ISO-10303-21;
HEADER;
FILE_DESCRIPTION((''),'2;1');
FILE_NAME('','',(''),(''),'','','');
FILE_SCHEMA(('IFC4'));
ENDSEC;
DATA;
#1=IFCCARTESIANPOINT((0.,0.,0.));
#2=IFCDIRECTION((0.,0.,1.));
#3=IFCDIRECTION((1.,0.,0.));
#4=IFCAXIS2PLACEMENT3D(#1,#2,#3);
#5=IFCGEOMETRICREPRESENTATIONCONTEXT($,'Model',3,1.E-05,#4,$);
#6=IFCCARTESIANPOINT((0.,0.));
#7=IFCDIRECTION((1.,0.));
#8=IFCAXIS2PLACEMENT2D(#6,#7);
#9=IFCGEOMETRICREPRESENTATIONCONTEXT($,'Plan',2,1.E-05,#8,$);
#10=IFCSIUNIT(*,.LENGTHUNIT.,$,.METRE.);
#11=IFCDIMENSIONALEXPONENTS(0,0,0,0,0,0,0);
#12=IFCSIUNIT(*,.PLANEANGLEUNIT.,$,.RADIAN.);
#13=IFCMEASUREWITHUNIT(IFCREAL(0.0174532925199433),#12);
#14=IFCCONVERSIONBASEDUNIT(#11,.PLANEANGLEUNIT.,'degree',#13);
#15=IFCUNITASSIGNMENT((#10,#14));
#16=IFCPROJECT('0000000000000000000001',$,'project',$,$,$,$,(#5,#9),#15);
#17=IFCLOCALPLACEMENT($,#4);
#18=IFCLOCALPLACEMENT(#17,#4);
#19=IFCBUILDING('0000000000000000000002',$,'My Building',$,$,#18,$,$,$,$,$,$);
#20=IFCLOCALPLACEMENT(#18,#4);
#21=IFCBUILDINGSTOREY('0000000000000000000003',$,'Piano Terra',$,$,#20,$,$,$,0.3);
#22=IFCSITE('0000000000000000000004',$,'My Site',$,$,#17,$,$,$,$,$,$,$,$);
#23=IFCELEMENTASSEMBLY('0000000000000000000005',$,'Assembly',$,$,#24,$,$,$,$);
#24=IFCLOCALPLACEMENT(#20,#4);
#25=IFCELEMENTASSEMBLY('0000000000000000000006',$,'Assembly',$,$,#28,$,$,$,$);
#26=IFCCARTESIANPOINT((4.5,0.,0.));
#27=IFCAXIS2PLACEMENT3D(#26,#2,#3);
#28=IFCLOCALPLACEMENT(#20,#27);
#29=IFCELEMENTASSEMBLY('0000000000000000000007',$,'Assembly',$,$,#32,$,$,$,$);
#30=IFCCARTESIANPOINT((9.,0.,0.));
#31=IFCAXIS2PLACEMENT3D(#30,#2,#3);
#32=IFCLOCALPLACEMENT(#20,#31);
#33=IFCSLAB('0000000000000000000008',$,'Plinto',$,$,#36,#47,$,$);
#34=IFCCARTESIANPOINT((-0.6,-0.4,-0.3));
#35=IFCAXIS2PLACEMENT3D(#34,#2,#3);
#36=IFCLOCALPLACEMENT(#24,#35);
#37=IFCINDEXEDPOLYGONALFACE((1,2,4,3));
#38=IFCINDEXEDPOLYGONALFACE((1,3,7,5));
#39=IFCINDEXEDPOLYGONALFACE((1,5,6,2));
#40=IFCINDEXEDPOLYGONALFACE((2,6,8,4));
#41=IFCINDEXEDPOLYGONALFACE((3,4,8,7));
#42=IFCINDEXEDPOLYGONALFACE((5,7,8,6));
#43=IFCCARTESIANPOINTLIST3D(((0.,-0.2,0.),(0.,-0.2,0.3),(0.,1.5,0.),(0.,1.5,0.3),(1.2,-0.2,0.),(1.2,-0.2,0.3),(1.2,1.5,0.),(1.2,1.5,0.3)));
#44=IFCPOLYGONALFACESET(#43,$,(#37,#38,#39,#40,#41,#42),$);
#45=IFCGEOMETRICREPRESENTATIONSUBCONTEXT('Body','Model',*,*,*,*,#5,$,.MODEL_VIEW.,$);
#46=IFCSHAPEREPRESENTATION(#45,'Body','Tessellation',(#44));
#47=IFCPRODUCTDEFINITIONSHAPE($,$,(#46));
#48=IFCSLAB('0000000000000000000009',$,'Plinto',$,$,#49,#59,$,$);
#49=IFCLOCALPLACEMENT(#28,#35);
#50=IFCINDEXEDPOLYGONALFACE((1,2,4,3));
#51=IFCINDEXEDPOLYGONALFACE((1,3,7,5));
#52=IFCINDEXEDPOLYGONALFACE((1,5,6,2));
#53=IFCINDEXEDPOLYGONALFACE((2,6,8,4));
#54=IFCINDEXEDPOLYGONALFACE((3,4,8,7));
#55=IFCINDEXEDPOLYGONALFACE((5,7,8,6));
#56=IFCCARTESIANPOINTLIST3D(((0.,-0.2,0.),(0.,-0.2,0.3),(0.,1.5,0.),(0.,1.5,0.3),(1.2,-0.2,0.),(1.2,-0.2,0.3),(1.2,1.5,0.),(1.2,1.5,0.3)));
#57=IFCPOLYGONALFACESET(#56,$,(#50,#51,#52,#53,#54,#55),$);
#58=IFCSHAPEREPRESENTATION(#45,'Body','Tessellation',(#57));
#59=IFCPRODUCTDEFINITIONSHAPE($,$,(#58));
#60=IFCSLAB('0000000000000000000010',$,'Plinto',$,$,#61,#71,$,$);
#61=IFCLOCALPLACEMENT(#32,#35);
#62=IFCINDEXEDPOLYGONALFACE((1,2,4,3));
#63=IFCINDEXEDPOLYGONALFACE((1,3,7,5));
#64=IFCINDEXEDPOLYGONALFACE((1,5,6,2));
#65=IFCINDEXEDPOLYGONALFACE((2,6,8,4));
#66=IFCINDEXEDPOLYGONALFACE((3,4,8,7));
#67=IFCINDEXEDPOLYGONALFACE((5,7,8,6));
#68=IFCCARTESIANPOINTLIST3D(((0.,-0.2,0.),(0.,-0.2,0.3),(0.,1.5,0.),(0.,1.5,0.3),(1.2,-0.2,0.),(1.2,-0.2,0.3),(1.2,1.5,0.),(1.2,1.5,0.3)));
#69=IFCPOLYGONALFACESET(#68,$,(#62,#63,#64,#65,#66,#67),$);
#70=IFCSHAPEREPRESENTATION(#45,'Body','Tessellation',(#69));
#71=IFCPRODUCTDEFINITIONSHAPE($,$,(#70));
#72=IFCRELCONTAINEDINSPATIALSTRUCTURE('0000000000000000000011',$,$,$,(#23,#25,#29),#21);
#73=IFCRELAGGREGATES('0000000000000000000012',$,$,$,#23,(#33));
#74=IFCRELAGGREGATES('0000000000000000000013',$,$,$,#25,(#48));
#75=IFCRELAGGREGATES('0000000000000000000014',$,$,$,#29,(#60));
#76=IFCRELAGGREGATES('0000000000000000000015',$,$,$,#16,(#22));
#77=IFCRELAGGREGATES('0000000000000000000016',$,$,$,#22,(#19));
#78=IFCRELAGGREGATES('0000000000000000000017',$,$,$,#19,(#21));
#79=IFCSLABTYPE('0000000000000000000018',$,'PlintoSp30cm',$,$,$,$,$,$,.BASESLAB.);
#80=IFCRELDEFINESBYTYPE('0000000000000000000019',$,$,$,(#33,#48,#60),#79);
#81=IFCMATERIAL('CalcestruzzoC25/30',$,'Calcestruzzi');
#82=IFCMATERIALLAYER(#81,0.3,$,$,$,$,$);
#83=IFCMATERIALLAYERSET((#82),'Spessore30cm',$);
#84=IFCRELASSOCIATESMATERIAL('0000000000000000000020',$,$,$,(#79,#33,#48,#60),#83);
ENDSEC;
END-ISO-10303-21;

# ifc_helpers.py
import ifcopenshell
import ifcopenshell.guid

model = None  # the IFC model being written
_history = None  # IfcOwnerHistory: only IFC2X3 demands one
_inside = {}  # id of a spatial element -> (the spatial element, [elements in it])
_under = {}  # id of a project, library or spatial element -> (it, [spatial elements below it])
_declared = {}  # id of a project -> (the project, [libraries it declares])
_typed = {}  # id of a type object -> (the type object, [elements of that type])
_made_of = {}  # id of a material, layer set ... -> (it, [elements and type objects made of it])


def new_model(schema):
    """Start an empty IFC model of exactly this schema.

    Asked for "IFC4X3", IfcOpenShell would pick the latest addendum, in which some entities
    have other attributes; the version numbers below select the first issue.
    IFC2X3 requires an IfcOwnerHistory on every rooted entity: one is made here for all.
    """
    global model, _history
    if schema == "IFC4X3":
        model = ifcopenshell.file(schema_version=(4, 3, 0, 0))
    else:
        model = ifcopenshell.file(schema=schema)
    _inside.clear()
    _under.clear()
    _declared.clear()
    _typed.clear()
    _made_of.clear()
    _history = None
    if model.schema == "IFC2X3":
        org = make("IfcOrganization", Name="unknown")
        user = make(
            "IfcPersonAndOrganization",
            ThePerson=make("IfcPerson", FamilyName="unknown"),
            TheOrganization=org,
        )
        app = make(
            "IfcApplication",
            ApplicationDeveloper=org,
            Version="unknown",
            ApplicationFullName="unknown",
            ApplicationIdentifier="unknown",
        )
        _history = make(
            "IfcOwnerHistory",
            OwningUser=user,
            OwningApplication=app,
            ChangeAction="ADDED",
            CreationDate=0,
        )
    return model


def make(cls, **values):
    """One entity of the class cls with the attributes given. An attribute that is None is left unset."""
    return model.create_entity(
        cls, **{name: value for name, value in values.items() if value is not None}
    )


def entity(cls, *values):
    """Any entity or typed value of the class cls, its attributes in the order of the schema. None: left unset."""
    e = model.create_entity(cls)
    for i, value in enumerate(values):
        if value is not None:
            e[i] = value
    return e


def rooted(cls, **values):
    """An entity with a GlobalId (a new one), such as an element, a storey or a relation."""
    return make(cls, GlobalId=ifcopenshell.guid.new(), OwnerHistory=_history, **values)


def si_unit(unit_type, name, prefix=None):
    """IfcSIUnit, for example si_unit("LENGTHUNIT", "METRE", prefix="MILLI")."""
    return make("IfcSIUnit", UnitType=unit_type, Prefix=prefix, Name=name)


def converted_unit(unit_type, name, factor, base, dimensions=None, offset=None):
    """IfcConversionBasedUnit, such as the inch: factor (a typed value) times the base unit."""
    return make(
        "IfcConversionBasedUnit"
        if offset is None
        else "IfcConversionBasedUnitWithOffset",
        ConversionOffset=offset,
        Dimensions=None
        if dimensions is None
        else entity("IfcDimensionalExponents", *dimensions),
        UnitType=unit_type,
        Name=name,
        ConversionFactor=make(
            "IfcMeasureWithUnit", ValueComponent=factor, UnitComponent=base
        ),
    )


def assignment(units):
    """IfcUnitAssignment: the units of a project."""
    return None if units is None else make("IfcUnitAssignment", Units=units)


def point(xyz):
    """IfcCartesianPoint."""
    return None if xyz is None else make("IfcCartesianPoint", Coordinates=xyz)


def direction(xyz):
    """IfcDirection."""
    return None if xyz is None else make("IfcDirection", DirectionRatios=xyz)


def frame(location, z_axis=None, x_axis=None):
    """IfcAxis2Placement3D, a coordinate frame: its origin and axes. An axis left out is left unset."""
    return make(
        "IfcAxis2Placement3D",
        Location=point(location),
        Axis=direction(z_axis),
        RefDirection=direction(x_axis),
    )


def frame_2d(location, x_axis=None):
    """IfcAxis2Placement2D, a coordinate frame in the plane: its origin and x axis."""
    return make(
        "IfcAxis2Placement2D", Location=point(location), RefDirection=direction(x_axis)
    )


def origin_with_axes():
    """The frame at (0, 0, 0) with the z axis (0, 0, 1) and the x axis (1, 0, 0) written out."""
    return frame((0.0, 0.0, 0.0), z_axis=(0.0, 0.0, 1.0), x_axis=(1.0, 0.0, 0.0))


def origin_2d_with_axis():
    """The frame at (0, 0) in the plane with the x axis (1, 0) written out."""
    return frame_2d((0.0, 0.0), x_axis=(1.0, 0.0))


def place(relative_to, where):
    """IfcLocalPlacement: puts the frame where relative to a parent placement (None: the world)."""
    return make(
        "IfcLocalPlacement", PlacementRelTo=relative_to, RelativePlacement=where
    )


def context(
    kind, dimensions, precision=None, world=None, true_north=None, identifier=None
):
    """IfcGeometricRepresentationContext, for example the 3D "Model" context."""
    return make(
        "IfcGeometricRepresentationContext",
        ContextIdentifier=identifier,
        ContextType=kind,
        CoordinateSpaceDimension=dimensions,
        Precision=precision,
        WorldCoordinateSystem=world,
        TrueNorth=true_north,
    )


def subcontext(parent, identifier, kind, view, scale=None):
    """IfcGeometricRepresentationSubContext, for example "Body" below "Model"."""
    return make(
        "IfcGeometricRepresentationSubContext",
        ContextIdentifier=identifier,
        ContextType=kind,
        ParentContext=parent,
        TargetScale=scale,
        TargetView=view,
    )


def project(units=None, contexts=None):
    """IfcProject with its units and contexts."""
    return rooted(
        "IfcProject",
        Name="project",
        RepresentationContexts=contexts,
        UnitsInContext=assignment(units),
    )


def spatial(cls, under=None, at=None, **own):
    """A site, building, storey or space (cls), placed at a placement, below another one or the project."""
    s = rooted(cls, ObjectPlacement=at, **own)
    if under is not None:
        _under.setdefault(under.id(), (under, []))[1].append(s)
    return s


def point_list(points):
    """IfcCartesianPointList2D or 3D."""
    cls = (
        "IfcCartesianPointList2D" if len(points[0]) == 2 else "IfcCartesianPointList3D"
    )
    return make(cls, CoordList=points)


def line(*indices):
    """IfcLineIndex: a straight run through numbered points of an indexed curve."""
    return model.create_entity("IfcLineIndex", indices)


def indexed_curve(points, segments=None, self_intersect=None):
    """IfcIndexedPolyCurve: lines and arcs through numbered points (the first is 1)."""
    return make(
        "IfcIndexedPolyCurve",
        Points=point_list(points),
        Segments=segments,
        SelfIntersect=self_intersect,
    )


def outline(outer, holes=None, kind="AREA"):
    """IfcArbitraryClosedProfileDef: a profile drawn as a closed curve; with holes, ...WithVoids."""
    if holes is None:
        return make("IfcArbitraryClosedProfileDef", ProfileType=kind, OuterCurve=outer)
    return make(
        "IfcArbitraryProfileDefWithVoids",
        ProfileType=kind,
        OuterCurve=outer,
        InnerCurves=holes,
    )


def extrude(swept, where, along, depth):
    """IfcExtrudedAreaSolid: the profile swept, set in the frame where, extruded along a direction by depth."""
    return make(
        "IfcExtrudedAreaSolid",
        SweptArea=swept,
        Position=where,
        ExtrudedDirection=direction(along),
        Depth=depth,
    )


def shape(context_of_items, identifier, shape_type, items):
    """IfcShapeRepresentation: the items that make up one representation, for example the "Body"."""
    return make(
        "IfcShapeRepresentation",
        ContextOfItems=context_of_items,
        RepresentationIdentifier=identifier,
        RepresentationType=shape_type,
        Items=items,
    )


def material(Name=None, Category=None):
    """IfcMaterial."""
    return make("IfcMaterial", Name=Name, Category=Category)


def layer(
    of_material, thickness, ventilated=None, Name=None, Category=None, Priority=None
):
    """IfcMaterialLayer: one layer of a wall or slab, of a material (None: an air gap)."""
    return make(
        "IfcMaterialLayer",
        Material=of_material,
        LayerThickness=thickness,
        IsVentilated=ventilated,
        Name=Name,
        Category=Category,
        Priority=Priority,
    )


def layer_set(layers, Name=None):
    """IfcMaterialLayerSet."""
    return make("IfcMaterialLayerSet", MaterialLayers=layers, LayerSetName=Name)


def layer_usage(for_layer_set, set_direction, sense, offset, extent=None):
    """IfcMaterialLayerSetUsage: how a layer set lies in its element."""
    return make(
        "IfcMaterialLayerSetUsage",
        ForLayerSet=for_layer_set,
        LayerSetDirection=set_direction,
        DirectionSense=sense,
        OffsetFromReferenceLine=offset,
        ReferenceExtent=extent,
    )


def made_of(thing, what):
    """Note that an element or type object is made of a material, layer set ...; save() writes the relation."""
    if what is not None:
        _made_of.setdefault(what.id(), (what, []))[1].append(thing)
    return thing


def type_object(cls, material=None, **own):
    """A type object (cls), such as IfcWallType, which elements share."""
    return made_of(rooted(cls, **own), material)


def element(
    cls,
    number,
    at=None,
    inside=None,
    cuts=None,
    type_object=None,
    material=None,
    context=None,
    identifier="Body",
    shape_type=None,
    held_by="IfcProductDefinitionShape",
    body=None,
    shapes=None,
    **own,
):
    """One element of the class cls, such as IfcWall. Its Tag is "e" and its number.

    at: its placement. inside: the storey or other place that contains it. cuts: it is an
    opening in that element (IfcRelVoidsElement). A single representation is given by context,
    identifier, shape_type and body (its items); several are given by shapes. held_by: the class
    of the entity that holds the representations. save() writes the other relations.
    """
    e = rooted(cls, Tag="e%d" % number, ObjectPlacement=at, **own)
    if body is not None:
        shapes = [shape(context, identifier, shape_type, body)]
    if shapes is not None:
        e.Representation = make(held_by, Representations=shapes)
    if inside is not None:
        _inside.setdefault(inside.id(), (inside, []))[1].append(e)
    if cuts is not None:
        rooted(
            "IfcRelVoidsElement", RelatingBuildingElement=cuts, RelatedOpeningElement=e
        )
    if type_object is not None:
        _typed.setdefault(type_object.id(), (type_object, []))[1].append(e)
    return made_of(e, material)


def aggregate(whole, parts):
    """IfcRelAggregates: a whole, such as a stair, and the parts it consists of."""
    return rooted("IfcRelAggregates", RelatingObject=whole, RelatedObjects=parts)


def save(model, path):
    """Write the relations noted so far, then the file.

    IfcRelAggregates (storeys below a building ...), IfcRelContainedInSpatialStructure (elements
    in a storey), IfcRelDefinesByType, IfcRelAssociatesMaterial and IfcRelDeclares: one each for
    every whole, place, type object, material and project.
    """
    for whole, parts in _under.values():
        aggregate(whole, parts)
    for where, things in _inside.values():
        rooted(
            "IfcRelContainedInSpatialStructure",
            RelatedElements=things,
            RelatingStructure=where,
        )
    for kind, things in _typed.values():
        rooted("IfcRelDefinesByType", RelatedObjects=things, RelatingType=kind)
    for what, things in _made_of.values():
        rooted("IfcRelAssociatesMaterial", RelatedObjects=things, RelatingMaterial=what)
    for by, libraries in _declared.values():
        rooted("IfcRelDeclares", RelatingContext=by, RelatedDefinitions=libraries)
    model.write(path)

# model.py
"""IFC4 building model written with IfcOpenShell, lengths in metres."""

from ifc_helpers import new_model, entity, si_unit, converted_unit, frame, origin_with_axes, origin_2d_with_axis, place, context, subcontext, project, spatial, line, indexed_curve, outline, extrude, material, layer, layer_set, layer_usage, type_object, element, aggregate, save


model = new_model("IFC4")

# Units and contexts
model_context = context("Model", 3, precision=1e-05, world=origin_with_axes())
plan_context = context("Plan", 2, precision=1e-05, world=origin_2d_with_axis())
body_context = subcontext(model_context, "Body", "Model", "MODEL_VIEW")
ifc_project = project(units=[si_unit("LENGTHUNIT", "METRE"), converted_unit("PLANEANGLEUNIT", "degree", entity("IfcReal", 0.0174532925199433), si_unit("PLANEANGLEUNIT", "RADIAN"), dimensions=[0, 0, 0, 0, 0, 0, 0])], contexts=[model_context, plan_context])

# Site, building, storey
site_placement = place(None, origin_with_axes())
site = spatial("IfcSite", under=ifc_project, at=site_placement, Name="My Site")
building_placement = place(site_placement, origin_with_axes())
building = spatial("IfcBuilding", under=site, at=building_placement, Name="My Building")
storey_placement = place(building_placement, origin_with_axes())
storey = spatial("IfcBuildingStorey", under=building, at=storey_placement, Name="Piano Terra", Elevation=0.3)

# Element assemblies
assembly_1_placement = place(storey_placement, origin_with_axes())
assembly_1 = element("IfcElementAssembly", 1, at=assembly_1_placement, inside=storey, Name="Assembly")
assembly_2_placement = place(storey_placement, frame((4.5, 0.0, 0.0), z_axis=(0.0, 0.0, 1.0), x_axis=(1.0, 0.0, 0.0)))
assembly_2 = element("IfcElementAssembly", 2, at=assembly_2_placement, inside=storey, Name="Assembly")
assembly_3_placement = place(storey_placement, frame((9.0, 0.0, 0.0), z_axis=(0.0, 0.0, 1.0), x_axis=(1.0, 0.0, 0.0)))
assembly_3 = element("IfcElementAssembly", 3, at=assembly_3_placement, inside=storey, Name="Assembly")

# Slabs
ifc_material_1 = material(Name="CalcestruzzoC25/30", Category="Calcestruzzi")
ifc_layer = layer(ifc_material_1, 0.3)
ifc_layer_set = layer_set([ifc_layer], Name="Spessore30cm")
ifc_layer_usage_1 = layer_usage(ifc_layer_set, "AXIS3", "POSITIVE", 0.0)
slab_type = type_object("IfcSlabType", Name="PlintoSp30cm", PredefinedType="BASESLAB", material=ifc_layer_set)
slab_1_placement = place(assembly_1_placement, frame((-0.6, -0.4, -0.3), z_axis=(0.0, 0.0, 1.0), x_axis=(1.0, 0.0, 0.0)))
slab_1 = element("IfcSlab", 4, at=slab_1_placement, type_object=slab_type, material=ifc_layer_usage_1, Name="Plinto", context=body_context, shape_type="SweptSolid", body=[
    extrude(outline(indexed_curve([(1.2, 1.5), (1.2, -0.2), (0.0, -0.2), (0.0, 1.5)], segments=[line(4, 1), line(1, 2), line(2, 3), line(3, 4)], self_intersect=False)), None, (0.0, 0.0, 1.0), 0.3),
])
aggregate(assembly_1, [slab_1])
ifc_layer_usage_2 = layer_usage(ifc_layer_set, "AXIS3", "POSITIVE", 0.0)
slab_2_placement = place(assembly_2_placement, frame((-0.6, -0.4, -0.3), z_axis=(0.0, 0.0, 1.0), x_axis=(1.0, 0.0, 0.0)))
slab_2 = element("IfcSlab", 5, at=slab_2_placement, type_object=slab_type, material=ifc_layer_usage_2, Name="Plinto", context=body_context, shape_type="SweptSolid", body=[
    extrude(outline(indexed_curve([(1.2, 1.5), (1.2, -0.2), (0.0, -0.2), (0.0, 1.5)], segments=[line(4, 1), line(1, 2), line(2, 3), line(3, 4)], self_intersect=False)), None, (0.0, 0.0, 1.0), 0.3),
])
aggregate(assembly_2, [slab_2])
ifc_layer_usage_3 = layer_usage(ifc_layer_set, "AXIS3", "POSITIVE", 0.0)
slab_3_placement = place(assembly_3_placement, frame((-0.6, -0.4, -0.3), z_axis=(0.0, 0.0, 1.0), x_axis=(1.0, 0.0, 0.0)))
slab_3 = element("IfcSlab", 6, at=slab_3_placement, type_object=slab_type, material=ifc_layer_usage_3, Name="Plinto", context=body_context, shape_type="SweptSolid", body=[
    extrude(outline(indexed_curve([(1.2, 1.5), (1.2, -0.2), (0.0, -0.2), (0.0, 1.5)], segments=[line(4, 1), line(1, 2), line(2, 3), line(3, 4)], self_intersect=False)), None, (0.0, 0.0, 1.0), 0.3),
])
aggregate(assembly_3, [slab_3])

save(model, "model.ifc")
